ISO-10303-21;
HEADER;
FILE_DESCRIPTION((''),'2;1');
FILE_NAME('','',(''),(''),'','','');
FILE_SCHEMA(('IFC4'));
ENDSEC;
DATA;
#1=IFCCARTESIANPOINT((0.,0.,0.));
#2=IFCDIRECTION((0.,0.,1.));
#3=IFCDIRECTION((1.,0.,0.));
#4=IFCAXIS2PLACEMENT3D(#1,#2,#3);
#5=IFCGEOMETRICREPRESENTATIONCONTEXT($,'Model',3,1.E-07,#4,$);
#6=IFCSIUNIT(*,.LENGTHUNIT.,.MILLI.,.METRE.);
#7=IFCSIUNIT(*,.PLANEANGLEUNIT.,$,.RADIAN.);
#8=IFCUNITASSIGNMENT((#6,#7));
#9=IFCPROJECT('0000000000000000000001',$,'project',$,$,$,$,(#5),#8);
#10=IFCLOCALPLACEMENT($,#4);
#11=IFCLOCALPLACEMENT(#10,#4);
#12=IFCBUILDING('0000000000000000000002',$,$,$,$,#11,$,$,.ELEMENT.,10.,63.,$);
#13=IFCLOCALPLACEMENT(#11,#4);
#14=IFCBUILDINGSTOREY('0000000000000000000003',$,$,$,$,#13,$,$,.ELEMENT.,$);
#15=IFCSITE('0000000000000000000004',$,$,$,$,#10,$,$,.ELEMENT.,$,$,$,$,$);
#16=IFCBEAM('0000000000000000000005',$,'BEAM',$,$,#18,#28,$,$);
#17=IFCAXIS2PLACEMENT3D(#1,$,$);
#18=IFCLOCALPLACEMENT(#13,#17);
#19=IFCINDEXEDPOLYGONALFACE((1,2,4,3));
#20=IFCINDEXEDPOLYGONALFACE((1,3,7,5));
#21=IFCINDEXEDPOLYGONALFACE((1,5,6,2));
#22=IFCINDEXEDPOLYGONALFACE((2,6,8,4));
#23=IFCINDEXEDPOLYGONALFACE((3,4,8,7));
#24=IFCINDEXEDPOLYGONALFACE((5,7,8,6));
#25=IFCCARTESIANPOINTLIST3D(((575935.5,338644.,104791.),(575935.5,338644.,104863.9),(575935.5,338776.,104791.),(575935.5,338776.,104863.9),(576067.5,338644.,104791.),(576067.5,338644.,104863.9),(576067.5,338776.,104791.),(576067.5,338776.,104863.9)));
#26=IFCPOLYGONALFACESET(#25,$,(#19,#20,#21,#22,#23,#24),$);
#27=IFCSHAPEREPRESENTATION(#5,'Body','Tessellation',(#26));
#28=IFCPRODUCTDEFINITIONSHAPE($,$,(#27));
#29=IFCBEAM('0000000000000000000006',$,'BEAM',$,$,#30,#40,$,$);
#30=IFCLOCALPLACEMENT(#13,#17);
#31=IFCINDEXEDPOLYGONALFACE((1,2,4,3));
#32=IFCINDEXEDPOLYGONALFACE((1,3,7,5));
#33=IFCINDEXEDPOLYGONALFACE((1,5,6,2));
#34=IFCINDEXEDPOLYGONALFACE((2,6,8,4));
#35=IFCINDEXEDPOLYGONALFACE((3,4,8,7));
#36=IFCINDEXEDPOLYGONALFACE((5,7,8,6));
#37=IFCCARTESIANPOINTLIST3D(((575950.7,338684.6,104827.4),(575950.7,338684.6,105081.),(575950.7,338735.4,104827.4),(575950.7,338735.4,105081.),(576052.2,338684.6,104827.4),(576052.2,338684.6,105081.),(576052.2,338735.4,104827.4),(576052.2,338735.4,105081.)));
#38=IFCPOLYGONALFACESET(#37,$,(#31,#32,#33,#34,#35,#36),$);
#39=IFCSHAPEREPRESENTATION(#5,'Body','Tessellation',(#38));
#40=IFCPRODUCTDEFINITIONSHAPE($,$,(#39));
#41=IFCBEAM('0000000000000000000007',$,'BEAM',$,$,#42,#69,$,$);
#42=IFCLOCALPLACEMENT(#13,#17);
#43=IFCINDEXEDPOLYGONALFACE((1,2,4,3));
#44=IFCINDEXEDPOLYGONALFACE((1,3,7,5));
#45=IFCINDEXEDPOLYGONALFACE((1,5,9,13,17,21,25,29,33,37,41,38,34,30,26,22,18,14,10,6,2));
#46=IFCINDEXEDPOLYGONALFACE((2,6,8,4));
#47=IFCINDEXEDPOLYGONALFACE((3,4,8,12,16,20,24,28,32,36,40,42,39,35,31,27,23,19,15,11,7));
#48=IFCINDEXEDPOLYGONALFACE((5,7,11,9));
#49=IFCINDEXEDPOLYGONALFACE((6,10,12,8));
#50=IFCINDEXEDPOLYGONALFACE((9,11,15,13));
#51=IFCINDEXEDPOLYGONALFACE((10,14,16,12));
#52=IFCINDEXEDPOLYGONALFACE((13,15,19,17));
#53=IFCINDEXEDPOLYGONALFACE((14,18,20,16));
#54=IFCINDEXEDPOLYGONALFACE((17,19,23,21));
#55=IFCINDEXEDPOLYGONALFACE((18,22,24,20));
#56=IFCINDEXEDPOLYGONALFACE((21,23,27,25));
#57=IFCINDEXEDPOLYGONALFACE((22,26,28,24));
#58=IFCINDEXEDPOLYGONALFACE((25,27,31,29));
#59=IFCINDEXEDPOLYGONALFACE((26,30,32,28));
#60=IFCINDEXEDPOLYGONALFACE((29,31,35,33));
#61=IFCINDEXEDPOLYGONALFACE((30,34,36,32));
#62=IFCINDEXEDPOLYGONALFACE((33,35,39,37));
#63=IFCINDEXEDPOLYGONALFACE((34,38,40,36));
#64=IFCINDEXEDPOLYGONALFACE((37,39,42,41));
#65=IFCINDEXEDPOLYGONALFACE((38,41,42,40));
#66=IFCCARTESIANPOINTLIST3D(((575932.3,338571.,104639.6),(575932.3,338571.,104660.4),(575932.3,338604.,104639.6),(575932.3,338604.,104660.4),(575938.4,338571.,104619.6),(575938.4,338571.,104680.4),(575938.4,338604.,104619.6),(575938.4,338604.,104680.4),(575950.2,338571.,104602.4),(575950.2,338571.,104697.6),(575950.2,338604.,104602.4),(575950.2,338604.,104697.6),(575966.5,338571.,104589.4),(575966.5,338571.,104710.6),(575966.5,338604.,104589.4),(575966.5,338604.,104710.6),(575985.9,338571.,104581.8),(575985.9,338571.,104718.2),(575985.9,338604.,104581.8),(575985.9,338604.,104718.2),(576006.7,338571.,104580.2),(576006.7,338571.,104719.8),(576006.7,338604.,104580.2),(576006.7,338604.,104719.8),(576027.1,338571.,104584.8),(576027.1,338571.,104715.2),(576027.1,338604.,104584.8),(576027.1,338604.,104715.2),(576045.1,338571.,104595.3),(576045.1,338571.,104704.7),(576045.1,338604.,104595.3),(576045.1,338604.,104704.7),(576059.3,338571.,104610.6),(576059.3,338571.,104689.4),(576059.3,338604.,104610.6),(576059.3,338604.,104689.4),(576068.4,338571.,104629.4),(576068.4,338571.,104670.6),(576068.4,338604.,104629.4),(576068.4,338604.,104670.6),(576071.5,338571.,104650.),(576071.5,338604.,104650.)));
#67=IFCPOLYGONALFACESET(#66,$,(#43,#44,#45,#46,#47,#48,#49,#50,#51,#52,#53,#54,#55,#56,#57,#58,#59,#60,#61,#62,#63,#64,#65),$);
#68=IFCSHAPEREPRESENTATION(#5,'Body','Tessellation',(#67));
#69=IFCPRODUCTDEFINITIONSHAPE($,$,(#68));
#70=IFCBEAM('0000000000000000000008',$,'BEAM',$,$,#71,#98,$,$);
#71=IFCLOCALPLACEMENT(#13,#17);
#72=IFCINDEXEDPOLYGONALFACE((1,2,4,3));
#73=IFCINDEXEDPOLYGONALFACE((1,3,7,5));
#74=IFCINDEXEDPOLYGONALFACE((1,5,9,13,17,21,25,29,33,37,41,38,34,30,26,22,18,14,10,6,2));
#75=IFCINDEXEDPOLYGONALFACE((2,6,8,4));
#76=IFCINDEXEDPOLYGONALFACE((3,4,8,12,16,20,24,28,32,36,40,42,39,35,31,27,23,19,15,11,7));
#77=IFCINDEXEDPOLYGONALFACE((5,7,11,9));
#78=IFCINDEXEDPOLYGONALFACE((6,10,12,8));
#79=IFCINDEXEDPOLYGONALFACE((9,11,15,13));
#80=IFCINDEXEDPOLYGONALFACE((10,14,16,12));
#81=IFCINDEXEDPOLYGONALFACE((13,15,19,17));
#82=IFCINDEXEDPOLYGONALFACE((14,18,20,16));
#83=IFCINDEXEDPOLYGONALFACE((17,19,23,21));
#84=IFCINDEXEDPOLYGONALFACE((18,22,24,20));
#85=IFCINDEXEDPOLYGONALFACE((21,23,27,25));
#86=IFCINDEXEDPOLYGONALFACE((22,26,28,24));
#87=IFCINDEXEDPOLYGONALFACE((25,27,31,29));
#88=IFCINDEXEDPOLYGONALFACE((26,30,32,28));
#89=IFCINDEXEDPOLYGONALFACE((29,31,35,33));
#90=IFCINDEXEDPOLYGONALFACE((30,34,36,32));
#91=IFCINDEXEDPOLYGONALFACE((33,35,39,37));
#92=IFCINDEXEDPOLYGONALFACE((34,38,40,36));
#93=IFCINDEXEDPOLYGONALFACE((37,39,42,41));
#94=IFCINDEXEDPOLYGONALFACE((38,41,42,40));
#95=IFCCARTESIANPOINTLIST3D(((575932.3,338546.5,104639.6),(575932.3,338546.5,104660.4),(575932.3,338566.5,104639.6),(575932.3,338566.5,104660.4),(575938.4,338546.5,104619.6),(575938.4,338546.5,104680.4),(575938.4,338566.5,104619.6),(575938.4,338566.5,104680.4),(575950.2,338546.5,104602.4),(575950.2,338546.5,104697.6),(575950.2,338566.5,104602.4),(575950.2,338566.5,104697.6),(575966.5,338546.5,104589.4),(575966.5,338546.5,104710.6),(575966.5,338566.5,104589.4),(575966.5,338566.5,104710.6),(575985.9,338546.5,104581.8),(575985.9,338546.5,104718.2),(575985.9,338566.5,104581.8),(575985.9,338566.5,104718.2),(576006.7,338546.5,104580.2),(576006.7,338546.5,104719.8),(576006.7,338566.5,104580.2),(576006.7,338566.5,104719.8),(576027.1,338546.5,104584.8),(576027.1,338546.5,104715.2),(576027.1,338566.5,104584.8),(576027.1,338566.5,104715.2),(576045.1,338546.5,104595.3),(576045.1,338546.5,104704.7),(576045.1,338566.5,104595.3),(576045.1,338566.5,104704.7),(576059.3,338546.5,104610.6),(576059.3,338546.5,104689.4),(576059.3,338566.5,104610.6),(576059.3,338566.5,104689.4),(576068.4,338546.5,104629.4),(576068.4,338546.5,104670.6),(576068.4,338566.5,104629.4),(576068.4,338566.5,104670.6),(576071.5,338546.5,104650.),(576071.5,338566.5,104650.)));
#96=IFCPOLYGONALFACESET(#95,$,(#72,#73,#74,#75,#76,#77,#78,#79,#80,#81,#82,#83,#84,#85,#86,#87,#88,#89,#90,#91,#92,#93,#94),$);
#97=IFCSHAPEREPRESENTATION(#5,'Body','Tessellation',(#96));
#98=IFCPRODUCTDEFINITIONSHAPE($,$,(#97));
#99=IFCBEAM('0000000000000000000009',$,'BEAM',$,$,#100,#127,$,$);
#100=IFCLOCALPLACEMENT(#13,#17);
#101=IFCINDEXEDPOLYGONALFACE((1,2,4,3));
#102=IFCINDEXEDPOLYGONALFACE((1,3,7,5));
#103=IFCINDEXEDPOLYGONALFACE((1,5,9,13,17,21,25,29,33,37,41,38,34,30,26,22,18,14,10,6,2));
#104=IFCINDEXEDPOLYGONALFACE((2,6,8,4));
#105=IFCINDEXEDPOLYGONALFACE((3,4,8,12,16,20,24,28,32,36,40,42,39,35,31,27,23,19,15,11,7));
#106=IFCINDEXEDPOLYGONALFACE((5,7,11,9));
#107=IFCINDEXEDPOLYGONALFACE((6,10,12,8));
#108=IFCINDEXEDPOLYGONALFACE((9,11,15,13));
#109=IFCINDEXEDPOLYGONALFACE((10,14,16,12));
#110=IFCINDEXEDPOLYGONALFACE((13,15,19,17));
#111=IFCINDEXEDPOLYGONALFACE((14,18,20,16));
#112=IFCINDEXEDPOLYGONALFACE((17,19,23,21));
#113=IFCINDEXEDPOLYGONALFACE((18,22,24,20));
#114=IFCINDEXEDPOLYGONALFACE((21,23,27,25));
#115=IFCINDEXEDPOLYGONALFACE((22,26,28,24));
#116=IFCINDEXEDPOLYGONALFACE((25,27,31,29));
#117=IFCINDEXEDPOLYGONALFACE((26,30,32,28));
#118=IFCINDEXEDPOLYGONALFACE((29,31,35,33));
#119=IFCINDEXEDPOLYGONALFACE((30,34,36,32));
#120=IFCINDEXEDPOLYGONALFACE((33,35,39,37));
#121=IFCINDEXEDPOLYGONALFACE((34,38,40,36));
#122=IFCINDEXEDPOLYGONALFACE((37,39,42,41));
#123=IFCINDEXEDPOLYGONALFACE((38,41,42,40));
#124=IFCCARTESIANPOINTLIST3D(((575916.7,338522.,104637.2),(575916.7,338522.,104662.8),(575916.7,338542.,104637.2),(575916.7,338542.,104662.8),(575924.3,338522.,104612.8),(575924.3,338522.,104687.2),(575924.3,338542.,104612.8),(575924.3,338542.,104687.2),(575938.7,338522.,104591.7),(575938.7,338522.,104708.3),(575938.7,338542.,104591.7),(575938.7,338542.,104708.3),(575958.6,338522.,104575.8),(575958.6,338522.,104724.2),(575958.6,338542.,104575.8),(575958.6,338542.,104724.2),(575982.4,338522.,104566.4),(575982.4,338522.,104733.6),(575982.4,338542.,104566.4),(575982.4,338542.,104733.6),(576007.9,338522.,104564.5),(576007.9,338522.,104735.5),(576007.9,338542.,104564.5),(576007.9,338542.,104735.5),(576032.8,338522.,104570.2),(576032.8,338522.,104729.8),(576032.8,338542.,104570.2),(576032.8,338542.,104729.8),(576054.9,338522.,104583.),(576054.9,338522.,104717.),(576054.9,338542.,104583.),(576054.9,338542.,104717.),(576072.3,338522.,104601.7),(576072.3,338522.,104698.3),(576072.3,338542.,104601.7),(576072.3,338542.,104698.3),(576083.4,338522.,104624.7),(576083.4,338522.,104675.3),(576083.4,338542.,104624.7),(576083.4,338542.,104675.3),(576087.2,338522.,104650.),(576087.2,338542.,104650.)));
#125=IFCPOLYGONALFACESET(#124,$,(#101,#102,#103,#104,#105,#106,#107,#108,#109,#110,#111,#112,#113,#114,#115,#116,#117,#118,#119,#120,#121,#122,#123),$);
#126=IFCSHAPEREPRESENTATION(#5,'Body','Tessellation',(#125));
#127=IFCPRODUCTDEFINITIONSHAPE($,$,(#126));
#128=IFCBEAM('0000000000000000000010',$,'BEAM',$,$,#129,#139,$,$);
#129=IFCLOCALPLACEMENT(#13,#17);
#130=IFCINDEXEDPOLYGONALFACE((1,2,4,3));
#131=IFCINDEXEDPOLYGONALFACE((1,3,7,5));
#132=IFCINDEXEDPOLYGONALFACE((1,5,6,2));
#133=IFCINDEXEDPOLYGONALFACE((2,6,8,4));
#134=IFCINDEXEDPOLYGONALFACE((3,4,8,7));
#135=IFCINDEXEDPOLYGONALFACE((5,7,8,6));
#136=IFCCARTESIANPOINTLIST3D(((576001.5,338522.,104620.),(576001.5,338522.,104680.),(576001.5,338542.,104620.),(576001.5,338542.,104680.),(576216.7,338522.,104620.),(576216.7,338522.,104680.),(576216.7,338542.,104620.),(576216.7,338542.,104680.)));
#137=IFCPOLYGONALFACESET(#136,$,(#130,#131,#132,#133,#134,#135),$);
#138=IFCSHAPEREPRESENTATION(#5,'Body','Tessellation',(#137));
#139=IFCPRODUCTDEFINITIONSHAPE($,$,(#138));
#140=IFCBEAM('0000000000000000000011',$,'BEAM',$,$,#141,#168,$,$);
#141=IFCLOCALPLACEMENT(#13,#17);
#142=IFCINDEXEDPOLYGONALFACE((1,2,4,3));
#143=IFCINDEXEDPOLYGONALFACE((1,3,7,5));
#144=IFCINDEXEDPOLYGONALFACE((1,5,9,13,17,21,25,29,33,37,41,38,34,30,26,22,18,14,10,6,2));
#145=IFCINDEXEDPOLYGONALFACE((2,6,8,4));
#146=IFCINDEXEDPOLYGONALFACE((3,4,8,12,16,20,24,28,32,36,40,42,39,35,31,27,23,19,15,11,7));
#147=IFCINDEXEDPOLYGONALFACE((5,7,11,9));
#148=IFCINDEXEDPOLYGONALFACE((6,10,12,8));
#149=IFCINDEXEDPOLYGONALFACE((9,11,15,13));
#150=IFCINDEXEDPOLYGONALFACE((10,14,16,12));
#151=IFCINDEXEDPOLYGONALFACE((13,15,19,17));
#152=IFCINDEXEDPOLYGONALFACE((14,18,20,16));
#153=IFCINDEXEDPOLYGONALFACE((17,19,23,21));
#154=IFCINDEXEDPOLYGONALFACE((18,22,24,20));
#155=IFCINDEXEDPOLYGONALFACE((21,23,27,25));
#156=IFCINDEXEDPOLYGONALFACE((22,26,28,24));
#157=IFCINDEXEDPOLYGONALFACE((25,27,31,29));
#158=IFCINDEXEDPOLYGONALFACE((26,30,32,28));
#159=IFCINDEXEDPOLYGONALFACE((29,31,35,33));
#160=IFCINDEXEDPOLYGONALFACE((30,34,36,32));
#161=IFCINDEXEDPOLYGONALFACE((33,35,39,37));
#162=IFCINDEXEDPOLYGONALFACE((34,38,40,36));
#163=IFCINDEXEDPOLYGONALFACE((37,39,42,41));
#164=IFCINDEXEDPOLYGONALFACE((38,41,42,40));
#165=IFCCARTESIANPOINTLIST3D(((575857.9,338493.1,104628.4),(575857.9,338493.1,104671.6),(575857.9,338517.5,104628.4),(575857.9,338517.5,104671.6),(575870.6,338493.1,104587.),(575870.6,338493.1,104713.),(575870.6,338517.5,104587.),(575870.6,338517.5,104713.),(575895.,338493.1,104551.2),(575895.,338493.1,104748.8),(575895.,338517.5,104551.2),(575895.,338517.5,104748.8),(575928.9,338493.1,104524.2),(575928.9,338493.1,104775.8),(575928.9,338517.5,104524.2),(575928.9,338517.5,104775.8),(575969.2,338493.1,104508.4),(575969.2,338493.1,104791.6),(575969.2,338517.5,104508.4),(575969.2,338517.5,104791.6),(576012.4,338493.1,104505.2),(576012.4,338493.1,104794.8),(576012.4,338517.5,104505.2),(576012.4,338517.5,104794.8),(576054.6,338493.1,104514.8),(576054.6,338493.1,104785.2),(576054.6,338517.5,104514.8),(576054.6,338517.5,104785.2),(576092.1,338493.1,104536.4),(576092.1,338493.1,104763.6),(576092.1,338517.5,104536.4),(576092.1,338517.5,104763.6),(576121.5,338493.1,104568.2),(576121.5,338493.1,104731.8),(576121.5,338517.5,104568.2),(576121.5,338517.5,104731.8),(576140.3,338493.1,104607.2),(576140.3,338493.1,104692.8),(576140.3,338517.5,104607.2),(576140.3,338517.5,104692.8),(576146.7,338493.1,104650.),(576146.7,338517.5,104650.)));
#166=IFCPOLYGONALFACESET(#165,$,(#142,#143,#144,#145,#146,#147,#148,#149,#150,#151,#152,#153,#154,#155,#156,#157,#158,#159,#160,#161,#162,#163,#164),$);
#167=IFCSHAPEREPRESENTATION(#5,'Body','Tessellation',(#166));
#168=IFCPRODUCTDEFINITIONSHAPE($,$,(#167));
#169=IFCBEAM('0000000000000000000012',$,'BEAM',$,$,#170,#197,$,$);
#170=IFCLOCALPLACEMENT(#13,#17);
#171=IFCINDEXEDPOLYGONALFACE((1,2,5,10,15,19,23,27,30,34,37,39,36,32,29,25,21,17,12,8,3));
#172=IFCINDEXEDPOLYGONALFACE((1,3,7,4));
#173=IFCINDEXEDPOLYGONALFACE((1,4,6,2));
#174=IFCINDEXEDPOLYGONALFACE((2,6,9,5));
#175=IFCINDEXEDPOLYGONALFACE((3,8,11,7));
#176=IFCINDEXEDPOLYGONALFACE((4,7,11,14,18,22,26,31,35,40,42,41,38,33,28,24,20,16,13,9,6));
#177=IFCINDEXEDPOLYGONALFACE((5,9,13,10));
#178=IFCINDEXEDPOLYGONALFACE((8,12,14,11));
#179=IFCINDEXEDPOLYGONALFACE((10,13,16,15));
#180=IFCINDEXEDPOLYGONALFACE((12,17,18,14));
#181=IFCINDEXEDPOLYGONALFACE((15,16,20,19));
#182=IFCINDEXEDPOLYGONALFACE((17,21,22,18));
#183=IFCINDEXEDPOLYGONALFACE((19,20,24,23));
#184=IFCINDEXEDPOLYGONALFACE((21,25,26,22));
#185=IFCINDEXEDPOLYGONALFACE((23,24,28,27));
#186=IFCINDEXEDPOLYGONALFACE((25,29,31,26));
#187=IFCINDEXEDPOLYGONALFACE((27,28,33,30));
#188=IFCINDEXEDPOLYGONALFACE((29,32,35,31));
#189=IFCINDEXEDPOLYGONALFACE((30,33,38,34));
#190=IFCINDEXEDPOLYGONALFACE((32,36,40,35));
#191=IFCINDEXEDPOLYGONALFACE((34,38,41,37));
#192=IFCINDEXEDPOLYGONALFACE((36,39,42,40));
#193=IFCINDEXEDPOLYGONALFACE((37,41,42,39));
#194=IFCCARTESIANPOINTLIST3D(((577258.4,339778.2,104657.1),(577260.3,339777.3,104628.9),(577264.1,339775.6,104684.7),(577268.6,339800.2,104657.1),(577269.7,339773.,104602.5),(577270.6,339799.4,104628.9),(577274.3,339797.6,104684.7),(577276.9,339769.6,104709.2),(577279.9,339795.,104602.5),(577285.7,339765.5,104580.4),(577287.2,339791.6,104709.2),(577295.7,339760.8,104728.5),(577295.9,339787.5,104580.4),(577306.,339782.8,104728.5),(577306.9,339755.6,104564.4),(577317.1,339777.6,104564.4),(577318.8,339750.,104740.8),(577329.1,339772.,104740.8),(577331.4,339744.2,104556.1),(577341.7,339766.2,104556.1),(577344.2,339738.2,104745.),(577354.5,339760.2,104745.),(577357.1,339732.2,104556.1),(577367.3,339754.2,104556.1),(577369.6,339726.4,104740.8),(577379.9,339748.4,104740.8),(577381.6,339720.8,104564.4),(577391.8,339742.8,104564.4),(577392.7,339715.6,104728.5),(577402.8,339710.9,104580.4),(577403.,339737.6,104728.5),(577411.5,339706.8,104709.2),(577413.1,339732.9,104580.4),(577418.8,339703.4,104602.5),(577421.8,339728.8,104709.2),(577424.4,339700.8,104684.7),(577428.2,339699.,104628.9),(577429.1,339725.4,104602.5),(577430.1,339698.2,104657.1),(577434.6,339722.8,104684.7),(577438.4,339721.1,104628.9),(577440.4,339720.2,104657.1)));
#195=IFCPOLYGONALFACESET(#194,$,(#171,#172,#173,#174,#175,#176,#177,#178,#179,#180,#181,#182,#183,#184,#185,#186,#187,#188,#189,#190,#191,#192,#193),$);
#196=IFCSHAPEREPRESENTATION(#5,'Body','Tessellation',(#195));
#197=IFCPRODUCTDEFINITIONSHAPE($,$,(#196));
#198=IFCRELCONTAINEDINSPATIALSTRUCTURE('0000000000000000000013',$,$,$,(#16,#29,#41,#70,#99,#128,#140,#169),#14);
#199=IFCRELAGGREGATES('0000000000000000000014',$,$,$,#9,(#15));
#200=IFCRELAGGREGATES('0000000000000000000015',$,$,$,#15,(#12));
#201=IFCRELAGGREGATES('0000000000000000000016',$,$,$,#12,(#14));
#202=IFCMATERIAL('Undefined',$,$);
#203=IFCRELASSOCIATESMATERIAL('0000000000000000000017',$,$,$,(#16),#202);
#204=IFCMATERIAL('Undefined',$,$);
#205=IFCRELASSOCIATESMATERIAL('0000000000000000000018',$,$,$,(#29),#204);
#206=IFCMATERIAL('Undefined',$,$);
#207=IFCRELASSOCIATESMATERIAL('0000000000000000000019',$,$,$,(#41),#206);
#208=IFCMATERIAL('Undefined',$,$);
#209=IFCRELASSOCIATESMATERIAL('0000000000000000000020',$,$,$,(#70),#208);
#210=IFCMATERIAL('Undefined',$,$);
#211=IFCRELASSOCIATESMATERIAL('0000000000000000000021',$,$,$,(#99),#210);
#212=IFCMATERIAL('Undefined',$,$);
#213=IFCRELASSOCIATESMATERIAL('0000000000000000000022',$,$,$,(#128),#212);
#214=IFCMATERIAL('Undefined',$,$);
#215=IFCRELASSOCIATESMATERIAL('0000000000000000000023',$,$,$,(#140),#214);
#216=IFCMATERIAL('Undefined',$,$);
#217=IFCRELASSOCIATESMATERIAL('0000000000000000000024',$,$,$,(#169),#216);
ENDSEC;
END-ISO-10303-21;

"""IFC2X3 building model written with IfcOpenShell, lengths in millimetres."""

from ifc_helpers import new_model, si_unit, frame, origin_with_axes, origin_2d_with_axis, place, context, project, spatial, rectangle, circle, extrude, material, element, save


model = new_model("IFC2X3")

# Units and contexts
model_context = context("Model", 3, precision=1e-07, world=origin_with_axes())
ifc_project = project(units=[si_unit("LENGTHUNIT", "METRE", prefix="MILLI"), si_unit("PLANEANGLEUNIT", "RADIAN")], contexts=[model_context])

# Site, building, storey
site_placement = place(None, origin_with_axes())
site = spatial("IfcSite", under=ifc_project, at=site_placement, CompositionType="ELEMENT")
building_placement = place(site_placement, origin_with_axes())
building = spatial("IfcBuilding", under=site, at=building_placement, CompositionType="ELEMENT", ElevationOfRefHeight=10.0, ElevationOfTerrain=63.0)
storey_placement = place(building_placement, origin_with_axes())
storey = spatial("IfcBuildingStorey", under=building, at=storey_placement, CompositionType="ELEMENT")

# Beams
ifc_material_1 = material(Name="Undefined")
beam_1_placement = place(storey_placement, frame((576001.5, 338710.0, 104827.4), z_axis=(0.0, 0.0, 1.0), x_axis=(1.0, 0.0, 0.0)))
element("IfcBeam", 1, at=beam_1_placement, inside=storey, material=ifc_material_1, Name="BEAM", context=model_context, shape_type="SweptSolid", body=[
    extrude(rectangle(XDim=131.9, YDim=131.9, at=origin_2d_with_axis()), frame((0.0, 0.0, -36.5), z_axis=(0.0, 0.0, 1.0), x_axis=(0.0, -1.0, 0.0)), (0.0, 0.0, 1.0), 72.9),
])
ifc_material_2 = material(Name="Undefined")
beam_2_placement = place(storey_placement, frame((576001.5, 338710.0, 104954.2), z_axis=(0.0, 0.0, 1.0), x_axis=(1.0, 0.0, 0.0)))
element("IfcBeam", 2, at=beam_2_placement, inside=storey, material=ifc_material_2, Name="BEAM", context=model_context, shape_type="SweptSolid", body=[
    extrude(rectangle(XDim=50.8, YDim=101.5, at=origin_2d_with_axis()), frame((0.0, 0.0, -126.8), z_axis=(0.0, 0.0, 1.0), x_axis=(0.0, -1.0, 0.0)), (0.0, 0.0, 1.0), 253.5),
])
ifc_material_3 = material(Name="Undefined")
beam_3_placement = place(storey_placement, frame((576001.5, 338587.5, 104650.0), z_axis=(0.0, 1.0, 0.0), x_axis=(0.0, 0.0, -1.0)))
element("IfcBeam", 3, at=beam_3_placement, inside=storey, material=ifc_material_3, Name="BEAM", context=model_context, shape_type="SweptSolid", body=[
    extrude(circle(Radius=70.0, at=origin_2d_with_axis()), frame((0.0, 0.0, -16.5), z_axis=(0.0, 0.0, 1.0), x_axis=(0.0, -1.0, 0.0)), (0.0, 0.0, 1.0), 33.0),
])
ifc_material_4 = material(Name="Undefined")
beam_4_placement = place(storey_placement, frame((576001.5, 338556.5, 104650.0), z_axis=(0.0, 1.0, 0.0), x_axis=(0.0, 0.0, -1.0)))
element("IfcBeam", 4, at=beam_4_placement, inside=storey, material=ifc_material_4, Name="BEAM", context=model_context, shape_type="SweptSolid", body=[
    extrude(circle(Radius=70.0, at=origin_2d_with_axis()), frame((0.0, 0.0, -10.0), z_axis=(0.0, 0.0, 1.0), x_axis=(0.0, -1.0, 0.0)), (0.0, 0.0, 1.0), 20.0),
])
ifc_material_5 = material(Name="Undefined")
beam_5_placement = place(storey_placement, frame((576001.5, 338532.0, 104650.0), z_axis=(0.0, -1.0, 0.0), x_axis=(0.0, 0.0, 1.0)))
element("IfcBeam", 5, at=beam_5_placement, inside=storey, material=ifc_material_5, Name="BEAM", context=model_context, shape_type="SweptSolid", body=[
    extrude(circle(Radius=85.7, at=origin_2d_with_axis()), frame((0.0, 0.0, -10.0), z_axis=(0.0, 0.0, 1.0), x_axis=(0.0, -1.0, 0.0)), (0.0, 0.0, 1.0), 20.0),
])
ifc_material_6 = material(Name="Undefined")
beam_6_placement = place(storey_placement, frame((576109.1, 338532.0, 104650.0), z_axis=(0.0, 0.0, 1.0), x_axis=(1.0, 0.0, 0.0)))
element("IfcBeam", 6, at=beam_6_placement, inside=storey, material=ifc_material_6, Name="BEAM", context=model_context, shape_type="SweptSolid", body=[
    extrude(rectangle(XDim=20.0, YDim=215.2, at=origin_2d_with_axis()), frame((0.0, 0.0, -30.0), z_axis=(0.0, 0.0, 1.0), x_axis=(0.0, -1.0, 0.0)), (0.0, 0.0, 1.0), 60.0),
])
ifc_material_7 = material(Name="Undefined")
beam_7_placement = place(storey_placement, frame((576001.5, 338505.3, 104650.0), z_axis=(0.0, -1.0, 0.0), x_axis=(0.0, 0.0, 1.0)))
element("IfcBeam", 7, at=beam_7_placement, inside=storey, material=ifc_material_7, Name="BEAM", context=model_context, shape_type="SweptSolid", body=[
    extrude(circle(Radius=145.2, at=origin_2d_with_axis()), frame((0.0, 0.0, -12.2), z_axis=(0.0, 0.0, 1.0), x_axis=(0.0, -1.0, 0.0)), (0.0, 0.0, 1.0), 24.4),
])
ifc_material_8 = material(Name="Undefined")
beam_8_placement = place(storey_placement, frame((577349.4, 339749.2, 104650.0), z_axis=(-0.422618, -0.906308, 0.0), x_axis=(-0.906308, 0.422618, 0.0)))
element("IfcBeam", 8, at=beam_8_placement, inside=storey, material=ifc_material_8, Name="BEAM", context=model_context, shape_type="SweptSolid", body=[
    extrude(circle(Radius=95.0, at=origin_2d_with_axis()), frame((0.0, 0.0, -12.2), z_axis=(0.0, 0.0, 1.0), x_axis=(0.0, -1.0, 0.0)), (0.0, 0.0, 1.0), 24.3),
])

save(model, "model.ifc")
